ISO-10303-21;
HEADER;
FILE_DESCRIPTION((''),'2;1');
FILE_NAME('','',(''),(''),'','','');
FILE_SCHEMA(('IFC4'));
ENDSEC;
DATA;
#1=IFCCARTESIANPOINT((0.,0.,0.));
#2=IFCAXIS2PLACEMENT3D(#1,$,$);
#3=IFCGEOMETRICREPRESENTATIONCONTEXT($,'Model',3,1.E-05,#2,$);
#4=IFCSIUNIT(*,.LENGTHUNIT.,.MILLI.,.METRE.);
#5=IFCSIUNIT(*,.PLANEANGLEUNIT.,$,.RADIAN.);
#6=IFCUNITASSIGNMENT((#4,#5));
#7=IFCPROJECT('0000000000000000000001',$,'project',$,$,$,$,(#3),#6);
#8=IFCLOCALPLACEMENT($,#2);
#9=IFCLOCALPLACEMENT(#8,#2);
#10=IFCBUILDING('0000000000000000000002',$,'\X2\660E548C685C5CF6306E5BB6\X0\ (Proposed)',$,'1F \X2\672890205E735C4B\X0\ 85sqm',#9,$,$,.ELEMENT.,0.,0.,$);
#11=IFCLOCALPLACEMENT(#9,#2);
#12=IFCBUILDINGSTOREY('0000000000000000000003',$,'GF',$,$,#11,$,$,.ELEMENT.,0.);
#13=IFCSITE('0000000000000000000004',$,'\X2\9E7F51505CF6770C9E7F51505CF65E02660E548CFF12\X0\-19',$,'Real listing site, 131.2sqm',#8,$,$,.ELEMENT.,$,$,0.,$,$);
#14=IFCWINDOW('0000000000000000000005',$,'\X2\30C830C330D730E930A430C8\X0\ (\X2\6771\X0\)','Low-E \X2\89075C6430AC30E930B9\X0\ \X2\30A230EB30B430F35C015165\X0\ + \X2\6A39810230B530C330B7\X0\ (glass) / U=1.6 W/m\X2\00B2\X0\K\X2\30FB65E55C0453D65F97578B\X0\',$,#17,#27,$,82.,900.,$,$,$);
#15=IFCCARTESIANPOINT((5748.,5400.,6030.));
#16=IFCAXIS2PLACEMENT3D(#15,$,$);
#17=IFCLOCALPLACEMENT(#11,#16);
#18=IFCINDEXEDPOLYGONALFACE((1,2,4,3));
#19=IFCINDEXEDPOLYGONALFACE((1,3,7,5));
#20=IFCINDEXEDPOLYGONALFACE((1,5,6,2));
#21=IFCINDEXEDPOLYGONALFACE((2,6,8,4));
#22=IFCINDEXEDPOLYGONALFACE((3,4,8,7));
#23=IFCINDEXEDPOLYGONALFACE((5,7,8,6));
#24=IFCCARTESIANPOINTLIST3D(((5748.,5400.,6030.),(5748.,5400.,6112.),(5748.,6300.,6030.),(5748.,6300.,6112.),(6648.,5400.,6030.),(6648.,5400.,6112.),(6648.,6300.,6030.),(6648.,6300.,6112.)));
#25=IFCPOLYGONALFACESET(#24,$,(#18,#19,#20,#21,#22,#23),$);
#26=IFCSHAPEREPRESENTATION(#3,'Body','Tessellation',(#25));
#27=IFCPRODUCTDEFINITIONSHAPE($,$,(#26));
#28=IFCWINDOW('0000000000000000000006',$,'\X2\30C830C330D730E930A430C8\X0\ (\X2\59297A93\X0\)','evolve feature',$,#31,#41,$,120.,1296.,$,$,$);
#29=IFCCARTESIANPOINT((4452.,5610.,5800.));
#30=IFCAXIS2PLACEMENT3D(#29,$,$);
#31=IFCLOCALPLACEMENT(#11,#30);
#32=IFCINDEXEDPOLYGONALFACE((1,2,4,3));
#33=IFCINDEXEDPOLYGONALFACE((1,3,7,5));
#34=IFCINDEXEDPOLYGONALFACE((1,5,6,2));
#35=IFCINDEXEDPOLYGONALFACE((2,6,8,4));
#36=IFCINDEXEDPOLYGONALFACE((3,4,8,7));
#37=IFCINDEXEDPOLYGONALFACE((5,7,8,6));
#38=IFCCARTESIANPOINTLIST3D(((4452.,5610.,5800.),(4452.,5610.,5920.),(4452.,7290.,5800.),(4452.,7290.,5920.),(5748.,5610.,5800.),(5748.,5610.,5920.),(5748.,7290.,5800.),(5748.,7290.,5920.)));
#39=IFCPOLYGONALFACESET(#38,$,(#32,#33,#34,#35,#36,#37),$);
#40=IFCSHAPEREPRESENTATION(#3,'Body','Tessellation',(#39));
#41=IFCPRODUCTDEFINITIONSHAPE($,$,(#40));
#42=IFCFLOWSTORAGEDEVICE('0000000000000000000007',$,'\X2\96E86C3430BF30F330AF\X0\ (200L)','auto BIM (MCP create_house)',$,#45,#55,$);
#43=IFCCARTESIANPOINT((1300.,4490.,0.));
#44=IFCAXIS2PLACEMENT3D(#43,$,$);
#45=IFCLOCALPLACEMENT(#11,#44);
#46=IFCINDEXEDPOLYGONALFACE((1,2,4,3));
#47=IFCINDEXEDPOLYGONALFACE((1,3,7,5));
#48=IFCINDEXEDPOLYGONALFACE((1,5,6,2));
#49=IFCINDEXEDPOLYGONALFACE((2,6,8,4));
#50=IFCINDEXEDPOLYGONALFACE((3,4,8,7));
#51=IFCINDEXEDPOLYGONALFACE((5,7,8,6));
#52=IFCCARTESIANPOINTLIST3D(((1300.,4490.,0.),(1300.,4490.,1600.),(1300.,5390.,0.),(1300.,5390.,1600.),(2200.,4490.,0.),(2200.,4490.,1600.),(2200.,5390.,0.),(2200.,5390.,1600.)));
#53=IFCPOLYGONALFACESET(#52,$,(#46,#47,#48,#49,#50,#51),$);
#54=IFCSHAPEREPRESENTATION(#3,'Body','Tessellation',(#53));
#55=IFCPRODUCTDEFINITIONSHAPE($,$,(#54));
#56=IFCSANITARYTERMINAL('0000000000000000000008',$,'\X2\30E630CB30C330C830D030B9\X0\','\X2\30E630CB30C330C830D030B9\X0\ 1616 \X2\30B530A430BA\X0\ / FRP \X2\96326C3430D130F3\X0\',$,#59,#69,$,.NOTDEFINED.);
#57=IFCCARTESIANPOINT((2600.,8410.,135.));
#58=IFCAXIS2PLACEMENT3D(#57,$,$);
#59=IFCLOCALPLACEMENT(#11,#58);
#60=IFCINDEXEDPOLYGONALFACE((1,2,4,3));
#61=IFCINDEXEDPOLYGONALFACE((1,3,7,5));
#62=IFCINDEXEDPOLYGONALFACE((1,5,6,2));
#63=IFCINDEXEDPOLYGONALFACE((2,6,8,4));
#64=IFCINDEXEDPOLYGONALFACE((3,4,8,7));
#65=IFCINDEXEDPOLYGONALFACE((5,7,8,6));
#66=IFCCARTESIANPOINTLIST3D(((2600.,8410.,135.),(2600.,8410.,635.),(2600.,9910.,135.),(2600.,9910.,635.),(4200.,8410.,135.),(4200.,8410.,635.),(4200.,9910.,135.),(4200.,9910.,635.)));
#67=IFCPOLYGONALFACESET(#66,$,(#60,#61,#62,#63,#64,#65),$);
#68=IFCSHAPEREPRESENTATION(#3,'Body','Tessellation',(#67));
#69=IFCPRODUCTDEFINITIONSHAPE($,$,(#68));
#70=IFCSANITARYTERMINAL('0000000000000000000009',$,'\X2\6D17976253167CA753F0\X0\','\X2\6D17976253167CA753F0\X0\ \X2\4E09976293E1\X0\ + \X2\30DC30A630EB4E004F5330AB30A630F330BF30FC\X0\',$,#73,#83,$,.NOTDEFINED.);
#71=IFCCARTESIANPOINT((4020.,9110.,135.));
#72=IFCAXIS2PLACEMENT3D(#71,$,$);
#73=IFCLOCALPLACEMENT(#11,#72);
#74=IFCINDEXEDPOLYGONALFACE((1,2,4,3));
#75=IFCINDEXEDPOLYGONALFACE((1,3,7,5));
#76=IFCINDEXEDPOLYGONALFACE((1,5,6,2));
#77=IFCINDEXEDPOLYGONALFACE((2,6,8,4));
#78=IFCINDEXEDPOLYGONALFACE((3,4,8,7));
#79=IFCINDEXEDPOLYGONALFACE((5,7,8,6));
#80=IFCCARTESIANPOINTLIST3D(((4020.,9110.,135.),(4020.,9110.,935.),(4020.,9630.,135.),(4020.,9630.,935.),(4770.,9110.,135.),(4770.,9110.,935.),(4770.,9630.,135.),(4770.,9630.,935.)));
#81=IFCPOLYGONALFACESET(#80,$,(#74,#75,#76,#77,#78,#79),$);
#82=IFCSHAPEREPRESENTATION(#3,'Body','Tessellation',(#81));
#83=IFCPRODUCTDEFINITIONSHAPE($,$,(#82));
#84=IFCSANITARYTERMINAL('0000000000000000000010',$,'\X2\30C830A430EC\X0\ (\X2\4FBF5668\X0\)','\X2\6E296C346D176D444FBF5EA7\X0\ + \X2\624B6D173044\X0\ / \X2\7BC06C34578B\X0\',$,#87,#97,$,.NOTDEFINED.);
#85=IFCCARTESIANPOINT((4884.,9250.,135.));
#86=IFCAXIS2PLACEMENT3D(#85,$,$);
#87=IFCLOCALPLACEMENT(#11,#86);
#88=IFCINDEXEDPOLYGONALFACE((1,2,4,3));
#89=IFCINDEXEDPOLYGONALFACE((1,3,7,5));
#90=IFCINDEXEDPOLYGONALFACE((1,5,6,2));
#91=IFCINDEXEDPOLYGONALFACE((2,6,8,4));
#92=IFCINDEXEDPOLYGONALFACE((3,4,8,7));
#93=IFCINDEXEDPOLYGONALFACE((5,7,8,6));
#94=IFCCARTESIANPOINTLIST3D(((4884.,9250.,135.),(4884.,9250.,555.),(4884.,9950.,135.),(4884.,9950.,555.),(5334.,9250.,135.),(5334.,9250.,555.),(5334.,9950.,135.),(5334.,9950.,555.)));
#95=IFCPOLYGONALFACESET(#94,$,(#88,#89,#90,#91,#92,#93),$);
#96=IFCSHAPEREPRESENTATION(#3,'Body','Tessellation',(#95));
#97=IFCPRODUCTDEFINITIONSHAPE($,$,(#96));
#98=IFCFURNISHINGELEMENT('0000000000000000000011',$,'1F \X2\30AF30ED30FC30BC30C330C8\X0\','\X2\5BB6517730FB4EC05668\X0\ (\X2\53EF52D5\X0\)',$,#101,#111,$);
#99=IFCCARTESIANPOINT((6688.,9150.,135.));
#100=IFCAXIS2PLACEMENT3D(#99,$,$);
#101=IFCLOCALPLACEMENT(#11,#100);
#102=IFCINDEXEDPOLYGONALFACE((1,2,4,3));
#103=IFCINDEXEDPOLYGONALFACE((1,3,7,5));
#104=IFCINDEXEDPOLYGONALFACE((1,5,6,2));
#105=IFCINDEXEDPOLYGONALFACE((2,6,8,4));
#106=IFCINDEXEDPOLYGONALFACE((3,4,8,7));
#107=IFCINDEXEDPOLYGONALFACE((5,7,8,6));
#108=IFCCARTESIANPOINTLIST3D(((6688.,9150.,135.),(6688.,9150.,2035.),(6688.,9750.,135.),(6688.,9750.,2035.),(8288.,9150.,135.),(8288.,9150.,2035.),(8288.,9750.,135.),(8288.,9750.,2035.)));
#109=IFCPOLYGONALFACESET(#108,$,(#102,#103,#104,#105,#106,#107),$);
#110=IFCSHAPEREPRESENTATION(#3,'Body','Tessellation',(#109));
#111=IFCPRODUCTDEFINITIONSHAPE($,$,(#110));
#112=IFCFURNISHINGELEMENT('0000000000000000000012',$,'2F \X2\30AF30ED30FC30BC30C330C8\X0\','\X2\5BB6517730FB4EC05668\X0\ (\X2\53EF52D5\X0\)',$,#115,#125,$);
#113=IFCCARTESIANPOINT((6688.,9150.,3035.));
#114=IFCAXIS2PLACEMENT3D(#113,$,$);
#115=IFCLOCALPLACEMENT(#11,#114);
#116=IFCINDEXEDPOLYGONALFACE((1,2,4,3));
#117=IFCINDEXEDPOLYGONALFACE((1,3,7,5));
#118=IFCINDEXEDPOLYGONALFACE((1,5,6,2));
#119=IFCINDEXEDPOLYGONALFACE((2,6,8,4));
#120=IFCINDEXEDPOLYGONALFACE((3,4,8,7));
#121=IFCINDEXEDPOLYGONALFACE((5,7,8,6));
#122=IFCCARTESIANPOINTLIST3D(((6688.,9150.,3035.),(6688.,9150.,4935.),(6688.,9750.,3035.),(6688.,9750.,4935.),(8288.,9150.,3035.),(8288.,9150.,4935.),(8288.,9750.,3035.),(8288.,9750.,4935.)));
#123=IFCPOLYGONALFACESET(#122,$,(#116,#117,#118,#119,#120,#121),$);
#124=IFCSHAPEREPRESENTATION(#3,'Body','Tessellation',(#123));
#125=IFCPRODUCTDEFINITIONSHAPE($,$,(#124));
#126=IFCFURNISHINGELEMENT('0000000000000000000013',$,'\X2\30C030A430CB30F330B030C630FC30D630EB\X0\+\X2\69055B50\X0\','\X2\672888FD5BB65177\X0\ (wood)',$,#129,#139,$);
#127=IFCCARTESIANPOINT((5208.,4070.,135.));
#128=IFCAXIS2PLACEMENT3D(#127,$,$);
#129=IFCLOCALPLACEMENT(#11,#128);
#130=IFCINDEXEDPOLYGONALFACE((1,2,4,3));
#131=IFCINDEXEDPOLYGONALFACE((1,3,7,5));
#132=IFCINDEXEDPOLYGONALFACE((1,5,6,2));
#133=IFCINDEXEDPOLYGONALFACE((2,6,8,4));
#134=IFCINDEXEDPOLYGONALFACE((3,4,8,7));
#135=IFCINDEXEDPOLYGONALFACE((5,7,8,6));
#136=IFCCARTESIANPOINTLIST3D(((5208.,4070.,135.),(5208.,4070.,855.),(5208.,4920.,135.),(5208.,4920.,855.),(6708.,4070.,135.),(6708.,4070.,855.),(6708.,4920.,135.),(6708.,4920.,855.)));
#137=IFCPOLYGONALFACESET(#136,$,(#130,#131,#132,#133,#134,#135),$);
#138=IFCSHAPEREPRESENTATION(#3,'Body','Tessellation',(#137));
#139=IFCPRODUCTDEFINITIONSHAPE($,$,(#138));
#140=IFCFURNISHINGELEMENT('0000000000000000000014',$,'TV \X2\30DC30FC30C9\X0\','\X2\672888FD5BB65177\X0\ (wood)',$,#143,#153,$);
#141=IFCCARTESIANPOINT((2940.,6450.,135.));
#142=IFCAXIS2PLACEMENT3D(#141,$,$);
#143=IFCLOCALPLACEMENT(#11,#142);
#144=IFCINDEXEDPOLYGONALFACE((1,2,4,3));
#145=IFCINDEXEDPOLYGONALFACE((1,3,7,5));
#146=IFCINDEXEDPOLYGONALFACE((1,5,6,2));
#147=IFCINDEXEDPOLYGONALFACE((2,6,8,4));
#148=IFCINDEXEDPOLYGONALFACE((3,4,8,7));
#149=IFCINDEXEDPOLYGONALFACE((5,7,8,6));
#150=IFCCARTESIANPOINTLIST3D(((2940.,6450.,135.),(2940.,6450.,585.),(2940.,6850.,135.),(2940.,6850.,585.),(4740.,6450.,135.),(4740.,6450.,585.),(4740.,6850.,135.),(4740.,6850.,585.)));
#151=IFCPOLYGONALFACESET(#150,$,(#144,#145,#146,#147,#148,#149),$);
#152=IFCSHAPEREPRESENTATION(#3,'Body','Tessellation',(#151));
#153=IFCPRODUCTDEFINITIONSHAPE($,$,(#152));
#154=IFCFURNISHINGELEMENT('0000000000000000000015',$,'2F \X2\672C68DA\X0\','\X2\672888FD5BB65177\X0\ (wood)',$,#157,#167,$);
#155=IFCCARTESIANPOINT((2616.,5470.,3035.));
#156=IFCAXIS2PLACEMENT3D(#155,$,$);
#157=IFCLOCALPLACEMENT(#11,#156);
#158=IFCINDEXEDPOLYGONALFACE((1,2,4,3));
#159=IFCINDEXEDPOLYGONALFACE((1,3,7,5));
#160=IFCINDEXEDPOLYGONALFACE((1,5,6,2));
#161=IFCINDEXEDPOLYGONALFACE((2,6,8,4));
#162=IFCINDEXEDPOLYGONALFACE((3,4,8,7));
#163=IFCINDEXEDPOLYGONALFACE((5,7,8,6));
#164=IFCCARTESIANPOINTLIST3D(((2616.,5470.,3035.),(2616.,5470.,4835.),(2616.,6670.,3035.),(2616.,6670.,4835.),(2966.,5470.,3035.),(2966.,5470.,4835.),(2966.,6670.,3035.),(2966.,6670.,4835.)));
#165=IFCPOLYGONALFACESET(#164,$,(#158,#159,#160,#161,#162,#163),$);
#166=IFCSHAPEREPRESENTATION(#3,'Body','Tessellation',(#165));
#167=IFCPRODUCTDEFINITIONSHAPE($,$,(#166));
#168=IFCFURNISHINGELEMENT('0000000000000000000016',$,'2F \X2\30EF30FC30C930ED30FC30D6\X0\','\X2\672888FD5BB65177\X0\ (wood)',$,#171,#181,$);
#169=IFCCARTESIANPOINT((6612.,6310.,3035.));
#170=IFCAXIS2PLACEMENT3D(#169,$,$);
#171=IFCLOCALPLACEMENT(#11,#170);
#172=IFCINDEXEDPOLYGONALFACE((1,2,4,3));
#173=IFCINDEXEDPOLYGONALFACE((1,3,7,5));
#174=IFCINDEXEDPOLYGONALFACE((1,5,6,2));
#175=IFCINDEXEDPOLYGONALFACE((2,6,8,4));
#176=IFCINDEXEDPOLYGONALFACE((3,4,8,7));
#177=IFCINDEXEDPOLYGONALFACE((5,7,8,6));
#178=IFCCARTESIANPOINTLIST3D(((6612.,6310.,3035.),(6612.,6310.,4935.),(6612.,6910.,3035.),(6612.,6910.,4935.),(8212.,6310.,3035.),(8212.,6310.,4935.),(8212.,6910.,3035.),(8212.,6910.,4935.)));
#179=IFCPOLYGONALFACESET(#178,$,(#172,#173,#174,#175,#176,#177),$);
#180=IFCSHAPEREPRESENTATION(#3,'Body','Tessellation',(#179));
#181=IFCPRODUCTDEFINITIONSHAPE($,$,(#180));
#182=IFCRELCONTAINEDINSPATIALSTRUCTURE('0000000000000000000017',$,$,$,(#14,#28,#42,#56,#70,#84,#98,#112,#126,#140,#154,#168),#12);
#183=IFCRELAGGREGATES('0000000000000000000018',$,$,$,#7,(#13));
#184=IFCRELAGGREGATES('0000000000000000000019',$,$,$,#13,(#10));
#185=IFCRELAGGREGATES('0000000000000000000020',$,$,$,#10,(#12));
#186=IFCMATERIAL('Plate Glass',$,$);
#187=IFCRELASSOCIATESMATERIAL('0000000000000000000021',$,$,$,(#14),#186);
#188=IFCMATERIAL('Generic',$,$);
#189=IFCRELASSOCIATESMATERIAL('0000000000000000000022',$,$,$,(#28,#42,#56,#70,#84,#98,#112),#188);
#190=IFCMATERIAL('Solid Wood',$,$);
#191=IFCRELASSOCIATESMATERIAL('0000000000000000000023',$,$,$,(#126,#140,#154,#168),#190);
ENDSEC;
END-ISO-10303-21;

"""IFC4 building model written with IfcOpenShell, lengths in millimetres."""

from ifc_helpers import new_model, si_unit, frame, frame_2d, origin, place, context, project, spatial, rectangle, extrude, material, element, save


model = new_model("IFC4")

# Units and contexts
model_context = context("Model", 3, precision=1e-05, world=origin())
ifc_project = project(units=[si_unit("LENGTHUNIT", "METRE", prefix="MILLI"), si_unit("PLANEANGLEUNIT", "RADIAN")], contexts=[model_context])

# Site, building, storey
site_placement = place(None, origin())
site = spatial("IfcSite", under=ifc_project, at=site_placement, Name="鹿児島県鹿児島市明和２-19", ObjectType="Real listing site, 131.2sqm", CompositionType="ELEMENT", RefElevation=0.0)
building_placement = place(site_placement, origin())
building = spatial("IfcBuilding", under=site, at=building_placement, Name="明和桜島の家 (Proposed)", ObjectType="1F 木造平屋 85sqm", CompositionType="ELEMENT", ElevationOfRefHeight=0.0, ElevationOfTerrain=0.0)
storey_placement = place(building_placement, origin())
storey = spatial("IfcBuildingStorey", under=building, at=storey_placement, Name="GF", CompositionType="ELEMENT", Elevation=0.0)

# Shared definitions
ifc_material_1 = material(Name="Solid Wood")
ifc_material_2 = material(Name="Plate Glass")

# Windows
window_1_placement = place(storey_placement, frame((5748.0, 5400.0, 6030.0)))
element("IfcWindow", 1, at=window_1_placement, inside=storey, material=ifc_material_2, Name="トップライト (東)", Description="Low-E 複層ガラス アルゴン封入 + 樹脂サッシ (glass) / U=1.6 W/m²K・日射取得型", OverallHeight=82.0, OverallWidth=900.0, context=model_context, shape_type="SweptSolid", body=[
    extrude(rectangle(XDim=900.0, YDim=900.0, at=frame_2d((450.0, 450.0))), frame((5748.0, 5400.0, 6030.0)), (0.0, 0.0, 1.0), 82.0),
])
ifc_material_3 = material(Name="Generic")
window_2_placement = place(storey_placement, frame((4452.0, 5610.0, 5800.0)))
element("IfcWindow", 2, at=window_2_placement, inside=storey, material=ifc_material_3, Name="トップライト (天窓)", Description="evolve feature", OverallHeight=120.0, OverallWidth=1296.0, context=model_context, shape_type="SweptSolid", body=[
    extrude(rectangle(XDim=1296.0, YDim=1680.0, at=frame_2d((648.0, 840.0))), frame((4452.0, 5610.0, 5800.0)), (0.0, 0.0, 1.0), 120.0),
])

# Flow storage device
flow_storage_device_placement = place(storey_placement, frame((1300.0, 4490.0, 0.0)))
element("IfcFlowStorageDevice", 3, at=flow_storage_device_placement, inside=storey, material=ifc_material_3, Name="雨水タンク (200L)", Description="auto BIM (MCP create_house)", context=model_context, shape_type="SweptSolid", body=[
    extrude(rectangle(XDim=900.0, YDim=900.0, at=frame_2d((450.0, 450.0))), frame((1300.0, 4490.0, 0.0)), (0.0, 0.0, 1.0), 1600.0),
])

# Sanitary terminals
sanitary_terminal_1_placement = place(storey_placement, frame((2600.0, 8410.0, 135.0)))
element("IfcSanitaryTerminal", 4, at=sanitary_terminal_1_placement, inside=storey, material=ifc_material_3, Name="ユニットバス", Description="ユニットバス 1616 サイズ / FRP 防水パン", PredefinedType="NOTDEFINED", context=model_context, shape_type="SweptSolid", body=[
    extrude(rectangle(XDim=1600.0, YDim=1500.0, at=frame_2d((800.0, 750.0))), frame((2600.0, 8410.0, 135.0)), (0.0, 0.0, 1.0), 500.0),
])
sanitary_terminal_2_placement = place(storey_placement, frame((4020.0, 9110.0, 135.0)))
element("IfcSanitaryTerminal", 5, at=sanitary_terminal_2_placement, inside=storey, material=ifc_material_3, Name="洗面化粧台", Description="洗面化粧台 三面鏡 + ボウル一体カウンター", PredefinedType="NOTDEFINED", context=model_context, shape_type="SweptSolid", body=[
    extrude(rectangle(XDim=750.0, YDim=520.0, at=frame_2d((375.0, 260.0))), frame((4020.0, 9110.0, 135.0)), (0.0, 0.0, 1.0), 800.0),
])
sanitary_terminal_3_placement = place(storey_placement, frame((4884.0, 9250.0, 135.0)))
element("IfcSanitaryTerminal", 6, at=sanitary_terminal_3_placement, inside=storey, material=ifc_material_3, Name="トイレ (便器)", Description="温水洗浄便座 + 手洗い / 節水型", PredefinedType="NOTDEFINED", context=model_context, shape_type="SweptSolid", body=[
    extrude(rectangle(XDim=450.0, YDim=700.0, at=frame_2d((225.0, 350.0))), frame((4884.0, 9250.0, 135.0)), (0.0, 0.0, 1.0), 420.0),
])

# Furnishing elements
furnishing_1_placement = place(storey_placement, frame((6688.0, 9150.0, 135.0)))
element("IfcFurnishingElement", 7, at=furnishing_1_placement, inside=storey, material=ifc_material_3, Name="1F クローゼット", Description="家具・什器 (可動)", context=model_context, shape_type="SweptSolid", body=[
    extrude(rectangle(XDim=1600.0, YDim=600.0, at=frame_2d((800.0, 300.0))), frame((6688.0, 9150.0, 135.0)), (0.0, 0.0, 1.0), 1900.0),
])
furnishing_2_placement = place(storey_placement, frame((6688.0, 9150.0, 3035.0)))
element("IfcFurnishingElement", 8, at=furnishing_2_placement, inside=storey, material=ifc_material_3, Name="2F クローゼット", Description="家具・什器 (可動)", context=model_context, shape_type="SweptSolid", body=[
    extrude(rectangle(XDim=1600.0, YDim=600.0, at=frame_2d((800.0, 300.0))), frame((6688.0, 9150.0, 3035.0)), (0.0, 0.0, 1.0), 1900.0),
])
furnishing_3_placement = place(storey_placement, frame((5208.0, 4070.0, 135.0)))
element("IfcFurnishingElement", 9, at=furnishing_3_placement, inside=storey, material=ifc_material_1, Name="ダイニングテーブル+椅子", Description="木製家具 (wood)", context=model_context, shape_type="SweptSolid", body=[
    extrude(rectangle(XDim=1500.0, YDim=850.0, at=frame_2d((750.0, 425.0))), frame((5208.0, 4070.0, 135.0)), (0.0, 0.0, 1.0), 720.0),
])
furnishing_4_placement = place(storey_placement, frame((2940.0, 6450.0, 135.0)))
element("IfcFurnishingElement", 10, at=furnishing_4_placement, inside=storey, material=ifc_material_1, Name="TV ボード", Description="木製家具 (wood)", context=model_context, shape_type="SweptSolid", body=[
    extrude(rectangle(XDim=1800.0, YDim=400.0, at=frame_2d((900.0, 200.0))), frame((2940.0, 6450.0, 135.0)), (0.0, 0.0, 1.0), 450.0),
])
furnishing_5_placement = place(storey_placement, frame((2616.0, 5470.0, 3035.0)))
element("IfcFurnishingElement", 11, at=furnishing_5_placement, inside=storey, material=ifc_material_1, Name="2F 本棚", Description="木製家具 (wood)", context=model_context, shape_type="SweptSolid", body=[
    extrude(rectangle(XDim=350.0, YDim=1200.0, at=frame_2d((175.0, 600.0))), frame((2616.0, 5470.0, 3035.0)), (0.0, 0.0, 1.0), 1800.0),
])
furnishing_6_placement = place(storey_placement, frame((6612.0, 6310.0, 3035.0)))
element("IfcFurnishingElement", 12, at=furnishing_6_placement, inside=storey, material=ifc_material_1, Name="2F ワードローブ", Description="木製家具 (wood)", context=model_context, shape_type="SweptSolid", body=[
    extrude(rectangle(XDim=1600.0, YDim=600.0, at=frame_2d((800.0, 300.0))), frame((6612.0, 6310.0, 3035.0)), (0.0, 0.0, 1.0), 1900.0),
])

save(model, "model.ifc")
